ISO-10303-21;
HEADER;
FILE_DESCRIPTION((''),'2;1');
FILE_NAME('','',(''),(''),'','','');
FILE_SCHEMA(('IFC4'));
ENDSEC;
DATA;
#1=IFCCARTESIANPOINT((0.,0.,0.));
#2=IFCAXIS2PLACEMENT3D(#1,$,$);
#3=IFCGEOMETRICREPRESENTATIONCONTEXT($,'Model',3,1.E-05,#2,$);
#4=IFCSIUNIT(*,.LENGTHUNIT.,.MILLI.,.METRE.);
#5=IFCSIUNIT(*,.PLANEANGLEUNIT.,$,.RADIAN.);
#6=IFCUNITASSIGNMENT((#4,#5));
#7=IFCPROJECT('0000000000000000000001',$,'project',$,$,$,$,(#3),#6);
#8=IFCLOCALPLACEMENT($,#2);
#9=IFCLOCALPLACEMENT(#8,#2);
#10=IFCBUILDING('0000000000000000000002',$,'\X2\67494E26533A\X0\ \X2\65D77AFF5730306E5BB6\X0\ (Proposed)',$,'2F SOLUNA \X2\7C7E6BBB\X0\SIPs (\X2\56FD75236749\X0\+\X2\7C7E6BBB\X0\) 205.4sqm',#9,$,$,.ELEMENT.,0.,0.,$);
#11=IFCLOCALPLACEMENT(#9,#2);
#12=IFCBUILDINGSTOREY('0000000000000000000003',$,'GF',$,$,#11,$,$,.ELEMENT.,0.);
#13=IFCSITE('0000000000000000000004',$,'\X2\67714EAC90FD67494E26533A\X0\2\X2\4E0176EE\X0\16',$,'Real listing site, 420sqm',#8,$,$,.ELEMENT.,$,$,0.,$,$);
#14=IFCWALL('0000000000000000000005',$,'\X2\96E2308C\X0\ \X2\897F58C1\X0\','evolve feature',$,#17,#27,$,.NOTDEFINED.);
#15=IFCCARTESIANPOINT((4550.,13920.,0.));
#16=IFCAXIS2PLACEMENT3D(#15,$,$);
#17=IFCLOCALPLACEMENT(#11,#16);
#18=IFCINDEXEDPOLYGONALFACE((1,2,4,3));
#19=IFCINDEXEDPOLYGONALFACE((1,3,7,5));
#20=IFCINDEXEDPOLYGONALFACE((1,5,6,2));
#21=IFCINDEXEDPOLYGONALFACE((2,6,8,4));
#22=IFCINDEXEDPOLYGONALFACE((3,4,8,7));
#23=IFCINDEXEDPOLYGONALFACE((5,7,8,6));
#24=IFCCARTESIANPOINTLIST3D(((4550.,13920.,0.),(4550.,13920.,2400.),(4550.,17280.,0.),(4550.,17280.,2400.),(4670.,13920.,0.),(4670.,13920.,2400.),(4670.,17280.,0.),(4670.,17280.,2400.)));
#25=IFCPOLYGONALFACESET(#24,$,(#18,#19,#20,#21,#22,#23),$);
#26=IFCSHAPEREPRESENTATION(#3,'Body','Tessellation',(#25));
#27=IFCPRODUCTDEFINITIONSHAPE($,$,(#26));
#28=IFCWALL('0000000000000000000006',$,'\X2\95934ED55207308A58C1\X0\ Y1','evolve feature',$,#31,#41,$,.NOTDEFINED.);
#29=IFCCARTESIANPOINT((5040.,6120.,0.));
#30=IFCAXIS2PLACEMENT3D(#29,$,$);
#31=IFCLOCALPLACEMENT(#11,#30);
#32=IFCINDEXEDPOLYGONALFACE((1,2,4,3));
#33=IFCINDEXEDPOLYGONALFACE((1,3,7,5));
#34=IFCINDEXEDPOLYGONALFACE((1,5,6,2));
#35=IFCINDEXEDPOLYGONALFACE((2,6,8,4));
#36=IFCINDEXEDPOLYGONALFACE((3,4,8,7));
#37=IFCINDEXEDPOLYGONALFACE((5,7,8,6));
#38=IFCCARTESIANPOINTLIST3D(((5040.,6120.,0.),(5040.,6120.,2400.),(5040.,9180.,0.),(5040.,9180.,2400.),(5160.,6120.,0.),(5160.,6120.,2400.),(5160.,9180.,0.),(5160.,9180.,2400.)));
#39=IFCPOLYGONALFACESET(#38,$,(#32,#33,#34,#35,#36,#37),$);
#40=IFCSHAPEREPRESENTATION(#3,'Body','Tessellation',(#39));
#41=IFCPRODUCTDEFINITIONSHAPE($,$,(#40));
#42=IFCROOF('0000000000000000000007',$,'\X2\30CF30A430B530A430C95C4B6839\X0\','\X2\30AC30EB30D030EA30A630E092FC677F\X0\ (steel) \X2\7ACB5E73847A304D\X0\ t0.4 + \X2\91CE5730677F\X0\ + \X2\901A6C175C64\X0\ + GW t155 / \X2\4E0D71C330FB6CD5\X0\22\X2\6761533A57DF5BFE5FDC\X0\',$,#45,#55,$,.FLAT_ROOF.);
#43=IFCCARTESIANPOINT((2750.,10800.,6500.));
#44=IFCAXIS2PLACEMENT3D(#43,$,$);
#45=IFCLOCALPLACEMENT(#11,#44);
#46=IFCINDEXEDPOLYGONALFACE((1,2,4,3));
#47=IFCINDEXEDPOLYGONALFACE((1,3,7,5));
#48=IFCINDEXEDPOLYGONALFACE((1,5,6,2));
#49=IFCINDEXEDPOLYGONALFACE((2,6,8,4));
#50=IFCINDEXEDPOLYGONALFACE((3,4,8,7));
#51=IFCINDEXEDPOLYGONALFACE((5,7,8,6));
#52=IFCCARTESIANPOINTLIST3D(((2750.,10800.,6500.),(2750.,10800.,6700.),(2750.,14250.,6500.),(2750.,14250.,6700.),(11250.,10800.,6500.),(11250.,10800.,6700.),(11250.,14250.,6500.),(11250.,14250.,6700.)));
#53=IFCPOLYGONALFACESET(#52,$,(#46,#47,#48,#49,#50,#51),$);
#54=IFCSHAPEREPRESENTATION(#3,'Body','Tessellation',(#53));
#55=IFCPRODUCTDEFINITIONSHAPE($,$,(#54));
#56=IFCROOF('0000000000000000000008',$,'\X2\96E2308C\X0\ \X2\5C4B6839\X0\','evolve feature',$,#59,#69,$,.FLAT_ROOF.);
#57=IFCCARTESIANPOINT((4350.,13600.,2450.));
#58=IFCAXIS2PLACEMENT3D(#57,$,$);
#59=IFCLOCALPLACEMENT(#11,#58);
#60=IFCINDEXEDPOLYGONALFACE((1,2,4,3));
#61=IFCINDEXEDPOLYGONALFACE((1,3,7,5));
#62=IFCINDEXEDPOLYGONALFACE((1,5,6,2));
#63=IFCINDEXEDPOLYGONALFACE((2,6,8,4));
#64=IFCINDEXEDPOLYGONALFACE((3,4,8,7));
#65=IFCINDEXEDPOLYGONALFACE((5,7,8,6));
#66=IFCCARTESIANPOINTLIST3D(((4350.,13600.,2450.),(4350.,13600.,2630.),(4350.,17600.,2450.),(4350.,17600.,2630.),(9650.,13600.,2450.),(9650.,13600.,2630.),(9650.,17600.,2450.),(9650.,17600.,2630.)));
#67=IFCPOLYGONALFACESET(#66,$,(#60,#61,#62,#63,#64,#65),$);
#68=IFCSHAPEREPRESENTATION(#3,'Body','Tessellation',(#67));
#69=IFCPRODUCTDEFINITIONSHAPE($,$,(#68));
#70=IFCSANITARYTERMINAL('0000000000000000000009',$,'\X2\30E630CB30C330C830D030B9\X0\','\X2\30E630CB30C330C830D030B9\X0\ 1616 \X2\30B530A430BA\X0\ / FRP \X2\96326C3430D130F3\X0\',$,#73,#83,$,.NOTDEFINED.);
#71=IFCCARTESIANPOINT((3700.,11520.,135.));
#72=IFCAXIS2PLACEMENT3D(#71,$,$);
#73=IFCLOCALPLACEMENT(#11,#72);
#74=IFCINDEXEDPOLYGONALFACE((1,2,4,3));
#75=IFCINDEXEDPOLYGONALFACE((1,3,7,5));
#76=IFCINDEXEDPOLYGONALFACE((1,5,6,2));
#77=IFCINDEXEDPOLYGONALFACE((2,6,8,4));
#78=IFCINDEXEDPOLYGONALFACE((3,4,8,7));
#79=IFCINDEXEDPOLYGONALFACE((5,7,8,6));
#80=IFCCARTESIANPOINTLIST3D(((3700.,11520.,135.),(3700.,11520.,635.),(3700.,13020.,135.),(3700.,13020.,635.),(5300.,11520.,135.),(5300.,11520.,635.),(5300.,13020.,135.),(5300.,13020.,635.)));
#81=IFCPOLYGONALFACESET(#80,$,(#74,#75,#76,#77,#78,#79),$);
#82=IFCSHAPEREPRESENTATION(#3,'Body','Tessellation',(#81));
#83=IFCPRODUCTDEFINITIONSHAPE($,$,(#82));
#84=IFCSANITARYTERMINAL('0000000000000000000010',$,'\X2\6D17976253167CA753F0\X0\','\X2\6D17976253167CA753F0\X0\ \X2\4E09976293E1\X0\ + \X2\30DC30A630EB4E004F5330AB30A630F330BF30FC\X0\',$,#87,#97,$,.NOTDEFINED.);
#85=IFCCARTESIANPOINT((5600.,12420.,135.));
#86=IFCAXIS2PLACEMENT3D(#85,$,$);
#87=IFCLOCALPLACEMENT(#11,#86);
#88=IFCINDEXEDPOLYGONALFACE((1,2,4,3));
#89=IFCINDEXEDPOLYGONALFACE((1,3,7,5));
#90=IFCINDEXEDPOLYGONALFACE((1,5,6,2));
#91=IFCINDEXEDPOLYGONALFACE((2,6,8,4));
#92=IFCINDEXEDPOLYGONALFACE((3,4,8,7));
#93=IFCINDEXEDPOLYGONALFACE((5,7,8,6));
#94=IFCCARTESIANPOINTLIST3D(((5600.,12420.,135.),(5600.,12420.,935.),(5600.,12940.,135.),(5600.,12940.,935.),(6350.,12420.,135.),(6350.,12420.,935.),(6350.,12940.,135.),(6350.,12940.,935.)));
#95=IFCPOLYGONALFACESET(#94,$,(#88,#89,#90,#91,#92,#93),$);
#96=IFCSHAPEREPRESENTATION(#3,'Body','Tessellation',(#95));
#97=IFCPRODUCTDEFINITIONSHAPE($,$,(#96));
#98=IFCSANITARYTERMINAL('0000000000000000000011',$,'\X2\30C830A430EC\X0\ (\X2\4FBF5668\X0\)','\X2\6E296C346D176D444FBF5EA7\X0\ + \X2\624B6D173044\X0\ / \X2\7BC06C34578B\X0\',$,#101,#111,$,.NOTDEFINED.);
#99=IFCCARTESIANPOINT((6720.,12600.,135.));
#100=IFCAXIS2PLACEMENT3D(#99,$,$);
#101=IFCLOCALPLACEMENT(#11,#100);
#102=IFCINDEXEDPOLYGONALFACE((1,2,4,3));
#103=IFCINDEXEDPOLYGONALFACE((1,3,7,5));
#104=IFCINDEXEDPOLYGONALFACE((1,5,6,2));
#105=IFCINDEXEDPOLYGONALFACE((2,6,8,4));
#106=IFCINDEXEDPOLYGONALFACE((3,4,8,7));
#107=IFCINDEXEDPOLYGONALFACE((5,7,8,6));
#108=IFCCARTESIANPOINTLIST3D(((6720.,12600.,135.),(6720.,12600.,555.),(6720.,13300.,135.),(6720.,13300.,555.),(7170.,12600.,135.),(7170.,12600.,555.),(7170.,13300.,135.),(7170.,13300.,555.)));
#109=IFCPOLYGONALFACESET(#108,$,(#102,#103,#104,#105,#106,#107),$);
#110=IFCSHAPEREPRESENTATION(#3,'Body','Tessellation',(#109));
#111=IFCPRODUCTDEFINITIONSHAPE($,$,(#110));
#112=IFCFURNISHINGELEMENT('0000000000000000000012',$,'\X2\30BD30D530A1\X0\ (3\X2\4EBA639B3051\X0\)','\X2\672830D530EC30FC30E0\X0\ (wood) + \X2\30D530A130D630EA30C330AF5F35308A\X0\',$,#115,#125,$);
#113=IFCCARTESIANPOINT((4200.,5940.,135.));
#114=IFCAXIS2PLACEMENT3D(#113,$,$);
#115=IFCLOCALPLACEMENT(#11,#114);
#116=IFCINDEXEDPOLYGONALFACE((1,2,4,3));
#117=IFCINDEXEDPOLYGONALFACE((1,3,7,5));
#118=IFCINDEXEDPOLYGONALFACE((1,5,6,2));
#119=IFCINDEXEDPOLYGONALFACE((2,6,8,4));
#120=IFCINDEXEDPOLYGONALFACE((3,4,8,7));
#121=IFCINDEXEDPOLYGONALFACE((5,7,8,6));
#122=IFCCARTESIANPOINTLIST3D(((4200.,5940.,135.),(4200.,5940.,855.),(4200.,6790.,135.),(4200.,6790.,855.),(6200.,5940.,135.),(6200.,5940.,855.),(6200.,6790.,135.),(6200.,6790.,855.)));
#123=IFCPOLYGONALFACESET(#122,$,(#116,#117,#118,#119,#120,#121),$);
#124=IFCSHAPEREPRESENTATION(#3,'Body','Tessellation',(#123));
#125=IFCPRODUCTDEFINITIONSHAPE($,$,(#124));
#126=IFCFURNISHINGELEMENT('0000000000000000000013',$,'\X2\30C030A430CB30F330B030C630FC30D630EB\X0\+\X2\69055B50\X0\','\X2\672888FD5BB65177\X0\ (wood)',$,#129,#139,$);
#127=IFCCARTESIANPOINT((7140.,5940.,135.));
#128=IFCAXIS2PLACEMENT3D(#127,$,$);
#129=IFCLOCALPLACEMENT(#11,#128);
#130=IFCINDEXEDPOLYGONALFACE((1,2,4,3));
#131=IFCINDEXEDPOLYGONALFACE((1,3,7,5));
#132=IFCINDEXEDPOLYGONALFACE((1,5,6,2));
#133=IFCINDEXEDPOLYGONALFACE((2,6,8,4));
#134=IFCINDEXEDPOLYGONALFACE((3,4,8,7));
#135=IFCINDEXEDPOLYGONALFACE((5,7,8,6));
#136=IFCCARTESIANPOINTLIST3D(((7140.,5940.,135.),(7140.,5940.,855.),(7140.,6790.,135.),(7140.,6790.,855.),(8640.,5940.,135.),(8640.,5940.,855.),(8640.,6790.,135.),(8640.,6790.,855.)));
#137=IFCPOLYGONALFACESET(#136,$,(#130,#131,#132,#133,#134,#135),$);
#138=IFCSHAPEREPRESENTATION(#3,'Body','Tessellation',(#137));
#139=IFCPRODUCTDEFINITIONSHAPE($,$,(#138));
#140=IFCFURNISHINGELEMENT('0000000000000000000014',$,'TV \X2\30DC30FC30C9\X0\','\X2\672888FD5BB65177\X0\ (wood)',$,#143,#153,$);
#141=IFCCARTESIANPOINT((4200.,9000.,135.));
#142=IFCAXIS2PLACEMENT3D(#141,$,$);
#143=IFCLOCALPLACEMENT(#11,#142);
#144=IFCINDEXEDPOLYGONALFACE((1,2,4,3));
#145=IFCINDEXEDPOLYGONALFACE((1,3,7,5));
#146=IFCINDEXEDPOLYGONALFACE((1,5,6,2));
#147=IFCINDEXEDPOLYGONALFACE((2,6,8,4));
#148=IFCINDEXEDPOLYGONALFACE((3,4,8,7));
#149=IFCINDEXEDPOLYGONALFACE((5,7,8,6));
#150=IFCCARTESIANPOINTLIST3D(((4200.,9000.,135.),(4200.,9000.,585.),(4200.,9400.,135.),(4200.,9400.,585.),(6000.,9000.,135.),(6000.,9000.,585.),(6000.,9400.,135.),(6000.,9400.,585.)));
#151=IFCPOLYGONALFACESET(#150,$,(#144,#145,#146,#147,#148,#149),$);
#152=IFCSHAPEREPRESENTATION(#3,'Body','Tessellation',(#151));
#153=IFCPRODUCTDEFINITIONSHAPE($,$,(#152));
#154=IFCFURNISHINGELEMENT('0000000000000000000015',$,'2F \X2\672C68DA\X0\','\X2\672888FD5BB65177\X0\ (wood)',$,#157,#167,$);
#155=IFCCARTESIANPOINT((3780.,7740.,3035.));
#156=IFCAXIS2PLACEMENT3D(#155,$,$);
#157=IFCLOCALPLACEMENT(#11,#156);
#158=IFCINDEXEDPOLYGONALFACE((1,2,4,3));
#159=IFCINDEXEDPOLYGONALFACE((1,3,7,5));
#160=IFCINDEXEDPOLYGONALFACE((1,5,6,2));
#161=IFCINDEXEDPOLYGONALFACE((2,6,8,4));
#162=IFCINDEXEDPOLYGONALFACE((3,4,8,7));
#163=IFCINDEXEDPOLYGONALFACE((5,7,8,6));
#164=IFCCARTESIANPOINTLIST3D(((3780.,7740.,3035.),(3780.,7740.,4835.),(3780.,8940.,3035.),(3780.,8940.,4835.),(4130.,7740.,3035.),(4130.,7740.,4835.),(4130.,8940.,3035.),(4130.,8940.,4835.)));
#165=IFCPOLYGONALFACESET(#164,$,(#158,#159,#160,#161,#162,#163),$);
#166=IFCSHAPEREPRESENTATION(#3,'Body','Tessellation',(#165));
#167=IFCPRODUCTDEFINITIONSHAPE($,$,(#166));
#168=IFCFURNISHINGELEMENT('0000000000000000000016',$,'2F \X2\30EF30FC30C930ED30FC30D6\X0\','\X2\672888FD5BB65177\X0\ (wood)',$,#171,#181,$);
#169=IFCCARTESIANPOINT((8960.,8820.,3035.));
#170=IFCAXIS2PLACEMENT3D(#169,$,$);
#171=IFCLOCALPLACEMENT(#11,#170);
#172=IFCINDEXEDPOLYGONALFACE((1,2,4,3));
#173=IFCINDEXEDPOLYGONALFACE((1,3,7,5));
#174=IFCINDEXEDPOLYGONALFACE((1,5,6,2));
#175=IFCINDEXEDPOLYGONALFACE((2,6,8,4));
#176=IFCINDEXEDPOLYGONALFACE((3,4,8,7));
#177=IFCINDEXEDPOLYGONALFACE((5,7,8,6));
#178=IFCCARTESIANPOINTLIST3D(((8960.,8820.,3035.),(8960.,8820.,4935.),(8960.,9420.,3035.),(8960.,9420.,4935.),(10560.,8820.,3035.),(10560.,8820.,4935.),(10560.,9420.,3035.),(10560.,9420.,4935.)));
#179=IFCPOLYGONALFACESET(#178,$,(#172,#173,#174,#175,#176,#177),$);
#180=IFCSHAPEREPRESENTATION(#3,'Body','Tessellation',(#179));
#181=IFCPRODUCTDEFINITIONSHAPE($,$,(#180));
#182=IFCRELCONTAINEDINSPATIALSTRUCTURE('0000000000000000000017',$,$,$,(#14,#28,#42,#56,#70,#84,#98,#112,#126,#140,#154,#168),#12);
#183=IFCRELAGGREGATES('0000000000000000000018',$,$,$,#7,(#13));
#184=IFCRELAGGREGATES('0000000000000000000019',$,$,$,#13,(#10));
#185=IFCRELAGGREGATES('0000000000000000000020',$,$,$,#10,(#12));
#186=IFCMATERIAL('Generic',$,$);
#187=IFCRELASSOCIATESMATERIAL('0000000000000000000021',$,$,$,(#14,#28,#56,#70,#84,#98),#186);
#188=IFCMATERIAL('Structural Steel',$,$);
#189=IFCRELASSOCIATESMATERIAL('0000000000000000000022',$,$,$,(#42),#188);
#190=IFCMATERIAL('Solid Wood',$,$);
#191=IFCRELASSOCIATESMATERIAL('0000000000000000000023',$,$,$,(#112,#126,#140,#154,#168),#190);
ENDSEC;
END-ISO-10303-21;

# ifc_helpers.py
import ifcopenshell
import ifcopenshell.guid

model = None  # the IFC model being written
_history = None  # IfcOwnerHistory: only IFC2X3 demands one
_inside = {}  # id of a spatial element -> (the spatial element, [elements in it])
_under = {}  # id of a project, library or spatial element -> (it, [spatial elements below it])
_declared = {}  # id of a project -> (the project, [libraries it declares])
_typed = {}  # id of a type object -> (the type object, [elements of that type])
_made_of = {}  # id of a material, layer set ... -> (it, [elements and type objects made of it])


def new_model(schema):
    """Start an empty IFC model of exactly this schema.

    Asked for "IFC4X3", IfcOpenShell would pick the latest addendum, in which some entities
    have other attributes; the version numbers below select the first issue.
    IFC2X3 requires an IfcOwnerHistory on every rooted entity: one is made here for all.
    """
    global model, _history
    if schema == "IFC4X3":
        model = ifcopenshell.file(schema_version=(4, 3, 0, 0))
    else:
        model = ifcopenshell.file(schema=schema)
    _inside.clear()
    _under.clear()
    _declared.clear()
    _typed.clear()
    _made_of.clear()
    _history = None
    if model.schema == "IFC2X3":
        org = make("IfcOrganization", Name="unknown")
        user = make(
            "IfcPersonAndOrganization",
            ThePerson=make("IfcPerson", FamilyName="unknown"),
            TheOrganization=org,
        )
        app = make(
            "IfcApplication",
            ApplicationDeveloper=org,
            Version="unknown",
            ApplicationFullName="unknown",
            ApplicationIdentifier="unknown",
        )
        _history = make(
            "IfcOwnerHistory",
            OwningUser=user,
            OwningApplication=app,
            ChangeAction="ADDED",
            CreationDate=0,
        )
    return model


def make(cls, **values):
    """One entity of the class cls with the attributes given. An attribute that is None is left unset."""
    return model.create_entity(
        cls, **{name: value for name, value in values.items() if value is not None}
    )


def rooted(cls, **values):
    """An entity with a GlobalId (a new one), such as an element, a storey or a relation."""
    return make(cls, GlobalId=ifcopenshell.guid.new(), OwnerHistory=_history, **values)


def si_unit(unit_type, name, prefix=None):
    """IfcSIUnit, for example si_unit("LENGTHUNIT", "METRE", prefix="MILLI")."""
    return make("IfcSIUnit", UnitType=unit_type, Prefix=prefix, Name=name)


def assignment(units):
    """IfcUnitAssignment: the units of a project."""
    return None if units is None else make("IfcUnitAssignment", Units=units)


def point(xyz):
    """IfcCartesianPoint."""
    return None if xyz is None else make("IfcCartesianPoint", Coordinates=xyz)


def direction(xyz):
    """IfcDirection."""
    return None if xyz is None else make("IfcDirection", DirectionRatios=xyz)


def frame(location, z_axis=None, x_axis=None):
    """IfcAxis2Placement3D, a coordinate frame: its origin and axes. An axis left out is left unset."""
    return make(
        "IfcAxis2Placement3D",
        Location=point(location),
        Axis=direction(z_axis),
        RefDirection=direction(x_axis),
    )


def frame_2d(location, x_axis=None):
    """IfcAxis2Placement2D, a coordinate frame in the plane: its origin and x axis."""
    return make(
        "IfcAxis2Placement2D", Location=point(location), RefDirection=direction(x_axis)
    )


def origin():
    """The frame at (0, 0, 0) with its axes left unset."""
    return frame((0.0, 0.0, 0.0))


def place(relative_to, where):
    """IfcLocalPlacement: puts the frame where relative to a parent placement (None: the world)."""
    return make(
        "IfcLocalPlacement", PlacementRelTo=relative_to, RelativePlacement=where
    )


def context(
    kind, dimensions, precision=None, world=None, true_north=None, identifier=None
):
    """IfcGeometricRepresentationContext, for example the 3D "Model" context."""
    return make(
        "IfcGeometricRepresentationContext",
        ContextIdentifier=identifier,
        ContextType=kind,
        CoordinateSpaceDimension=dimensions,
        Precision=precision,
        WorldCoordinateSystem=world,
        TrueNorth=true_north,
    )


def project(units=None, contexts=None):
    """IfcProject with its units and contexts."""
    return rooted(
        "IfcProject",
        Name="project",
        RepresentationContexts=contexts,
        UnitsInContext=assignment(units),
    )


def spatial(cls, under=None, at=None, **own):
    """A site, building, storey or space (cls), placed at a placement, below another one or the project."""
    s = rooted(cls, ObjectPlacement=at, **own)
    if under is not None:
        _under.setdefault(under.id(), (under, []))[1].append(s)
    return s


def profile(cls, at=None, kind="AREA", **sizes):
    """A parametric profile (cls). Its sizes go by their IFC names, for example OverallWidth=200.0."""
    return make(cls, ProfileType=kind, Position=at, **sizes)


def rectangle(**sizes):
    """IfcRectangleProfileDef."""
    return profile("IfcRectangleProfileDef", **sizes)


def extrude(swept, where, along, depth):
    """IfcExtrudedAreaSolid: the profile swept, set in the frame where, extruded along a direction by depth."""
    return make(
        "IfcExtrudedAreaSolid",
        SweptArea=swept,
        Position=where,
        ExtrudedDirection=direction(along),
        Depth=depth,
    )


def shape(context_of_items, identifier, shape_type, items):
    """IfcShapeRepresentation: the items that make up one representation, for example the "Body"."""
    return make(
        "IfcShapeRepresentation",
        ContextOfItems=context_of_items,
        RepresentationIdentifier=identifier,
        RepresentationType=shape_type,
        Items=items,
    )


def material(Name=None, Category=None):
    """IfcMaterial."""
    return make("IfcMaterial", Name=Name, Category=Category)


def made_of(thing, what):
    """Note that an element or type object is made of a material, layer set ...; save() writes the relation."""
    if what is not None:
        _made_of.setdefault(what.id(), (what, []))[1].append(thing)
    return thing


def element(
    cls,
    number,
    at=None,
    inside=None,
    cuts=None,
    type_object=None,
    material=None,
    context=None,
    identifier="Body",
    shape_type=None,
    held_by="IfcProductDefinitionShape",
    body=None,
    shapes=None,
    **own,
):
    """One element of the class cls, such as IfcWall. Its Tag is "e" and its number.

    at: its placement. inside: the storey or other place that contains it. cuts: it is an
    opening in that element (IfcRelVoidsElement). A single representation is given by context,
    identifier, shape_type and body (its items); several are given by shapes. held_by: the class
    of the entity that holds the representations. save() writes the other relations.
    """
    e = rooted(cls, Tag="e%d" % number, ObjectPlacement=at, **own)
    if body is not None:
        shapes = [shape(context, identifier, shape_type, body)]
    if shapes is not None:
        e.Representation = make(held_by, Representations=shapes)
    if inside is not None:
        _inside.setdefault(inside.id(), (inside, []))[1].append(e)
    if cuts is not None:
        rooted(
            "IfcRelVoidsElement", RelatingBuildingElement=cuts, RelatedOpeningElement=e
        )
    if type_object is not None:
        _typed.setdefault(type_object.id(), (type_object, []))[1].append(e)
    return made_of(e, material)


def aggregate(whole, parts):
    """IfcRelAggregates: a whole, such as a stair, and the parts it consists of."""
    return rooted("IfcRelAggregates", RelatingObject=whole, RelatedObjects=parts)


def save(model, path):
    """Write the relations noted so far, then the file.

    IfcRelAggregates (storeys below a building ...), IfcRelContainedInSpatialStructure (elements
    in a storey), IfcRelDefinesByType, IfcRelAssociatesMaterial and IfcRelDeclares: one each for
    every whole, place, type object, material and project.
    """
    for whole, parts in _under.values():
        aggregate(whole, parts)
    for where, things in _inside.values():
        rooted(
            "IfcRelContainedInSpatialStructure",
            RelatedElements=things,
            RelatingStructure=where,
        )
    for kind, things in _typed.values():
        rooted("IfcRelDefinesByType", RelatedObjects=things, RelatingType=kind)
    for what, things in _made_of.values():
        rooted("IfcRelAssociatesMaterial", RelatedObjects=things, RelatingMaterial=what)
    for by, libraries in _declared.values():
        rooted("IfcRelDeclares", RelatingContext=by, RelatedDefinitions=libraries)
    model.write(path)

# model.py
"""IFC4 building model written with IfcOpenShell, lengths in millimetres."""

from ifc_helpers import new_model, si_unit, frame, frame_2d, origin, place, context, project, spatial, rectangle, extrude, material, element, save


model = new_model("IFC4")

# Units and contexts
model_context = context("Model", 3, precision=1e-05, world=origin())
ifc_project = project(units=[si_unit("LENGTHUNIT", "METRE", prefix="MILLI"), si_unit("PLANEANGLEUNIT", "RADIAN")], contexts=[model_context])

# Site, building, storey
site_placement = place(None, origin())
site = spatial("IfcSite", under=ifc_project, at=site_placement, Name="東京都杉並区2丁目16", ObjectType="Real listing site, 420sqm", CompositionType="ELEMENT", RefElevation=0.0)
building_placement = place(site_placement, origin())
building = spatial("IfcBuilding", under=site, at=building_placement, Name="杉並区 旗竿地の家 (Proposed)", ObjectType="2F SOLUNA 籾殻SIPs (国産杉+籾殻) 205.4sqm", CompositionType="ELEMENT", ElevationOfRefHeight=0.0, ElevationOfTerrain=0.0)
storey_placement = place(building_placement, origin())
storey = spatial("IfcBuildingStorey", under=building, at=storey_placement, Name="GF", CompositionType="ELEMENT", Elevation=0.0)

# Shared definitions
ifc_material_1 = material(Name="Generic")

# Shared definitions
ifc_material_2 = material(Name="Solid Wood")

# Walls
wall_1_placement = place(storey_placement, frame((4550.0, 13920.0, 0.0)))
element("IfcWall", 1, at=wall_1_placement, inside=storey, material=ifc_material_1, Name="離れ 西壁", Description="evolve feature", PredefinedType="NOTDEFINED", context=model_context, shape_type="SweptSolid", body=[
    extrude(rectangle(XDim=120.0, YDim=3360.0, at=frame_2d((60.0, 1680.0))), frame((4550.0, 13920.0, 0.0)), (0.0, 0.0, 1.0), 2400.0),
])
wall_2_placement = place(storey_placement, frame((5040.0, 6120.0, 0.0)))
element("IfcWall", 2, at=wall_2_placement, inside=storey, material=ifc_material_1, Name="間仕切り壁 Y1", Description="evolve feature", PredefinedType="NOTDEFINED", context=model_context, shape_type="SweptSolid", body=[
    extrude(rectangle(XDim=120.0, YDim=3060.0, at=frame_2d((60.0, 1530.0))), frame((5040.0, 6120.0, 0.0)), (0.0, 0.0, 1.0), 2400.0),
])

# Roofs
ifc_material_3 = material(Name="Structural Steel")
roof_1_placement = place(storey_placement, frame((2750.0, 10800.0, 6500.0)))
element("IfcRoof", 3, at=roof_1_placement, inside=storey, material=ifc_material_3, Name="ハイサイド屋根", Description="ガルバリウム鋼板 (steel) 立平葺き t0.4 + 野地板 + 通気層 + GW t155 / 不燃・法22条区域対応", PredefinedType="FLAT_ROOF", context=model_context, shape_type="SweptSolid", body=[
    extrude(rectangle(XDim=8500.0, YDim=3450.0, at=frame_2d((4250.0, 1725.0))), frame((2750.0, 10800.0, 6500.0)), (0.0, 0.0, 1.0), 200.0),
])
roof_2_placement = place(storey_placement, frame((4350.0, 13600.0, 2450.0)))
element("IfcRoof", 4, at=roof_2_placement, inside=storey, material=ifc_material_1, Name="離れ 屋根", Description="evolve feature", PredefinedType="FLAT_ROOF", context=model_context, shape_type="SweptSolid", body=[
    extrude(rectangle(XDim=5300.0, YDim=4000.0, at=frame_2d((2650.0, 2000.0))), frame((4350.0, 13600.0, 2450.0)), (0.0, 0.0, 1.0), 180.0),
])

# Sanitary terminals
sanitary_terminal_1_placement = place(storey_placement, frame((3700.0, 11520.0, 135.0)))
element("IfcSanitaryTerminal", 5, at=sanitary_terminal_1_placement, inside=storey, material=ifc_material_1, Name="ユニットバス", Description="ユニットバス 1616 サイズ / FRP 防水パン", PredefinedType="NOTDEFINED", context=model_context, shape_type="SweptSolid", body=[
    extrude(rectangle(XDim=1600.0, YDim=1500.0, at=frame_2d((800.0, 750.0))), frame((3700.0, 11520.0, 135.0)), (0.0, 0.0, 1.0), 500.0),
])
sanitary_terminal_2_placement = place(storey_placement, frame((5600.0, 12420.0, 135.0)))
element("IfcSanitaryTerminal", 6, at=sanitary_terminal_2_placement, inside=storey, material=ifc_material_1, Name="洗面化粧台", Description="洗面化粧台 三面鏡 + ボウル一体カウンター", PredefinedType="NOTDEFINED", context=model_context, shape_type="SweptSolid", body=[
    extrude(rectangle(XDim=750.0, YDim=520.0, at=frame_2d((375.0, 260.0))), frame((5600.0, 12420.0, 135.0)), (0.0, 0.0, 1.0), 800.0),
])
sanitary_terminal_3_placement = place(storey_placement, frame((6720.0, 12600.0, 135.0)))
element("IfcSanitaryTerminal", 7, at=sanitary_terminal_3_placement, inside=storey, material=ifc_material_1, Name="トイレ (便器)", Description="温水洗浄便座 + 手洗い / 節水型", PredefinedType="NOTDEFINED", context=model_context, shape_type="SweptSolid", body=[
    extrude(rectangle(XDim=450.0, YDim=700.0, at=frame_2d((225.0, 350.0))), frame((6720.0, 12600.0, 135.0)), (0.0, 0.0, 1.0), 420.0),
])

# Furnishing elements
furnishing_1_placement = place(storey_placement, frame((4200.0, 5940.0, 135.0)))
element("IfcFurnishingElement", 8, at=furnishing_1_placement, inside=storey, material=ifc_material_2, Name="ソファ (3人掛け)", Description="木フレーム (wood) + ファブリック張り", context=model_context, shape_type="SweptSolid", body=[
    extrude(rectangle(XDim=2000.0, YDim=850.0, at=frame_2d((1000.0, 425.0))), frame((4200.0, 5940.0, 135.0)), (0.0, 0.0, 1.0), 720.0),
])
furnishing_2_placement = place(storey_placement, frame((7140.0, 5940.0, 135.0)))
element("IfcFurnishingElement", 9, at=furnishing_2_placement, inside=storey, material=ifc_material_2, Name="ダイニングテーブル+椅子", Description="木製家具 (wood)", context=model_context, shape_type="SweptSolid", body=[
    extrude(rectangle(XDim=1500.0, YDim=850.0, at=frame_2d((750.0, 425.0))), frame((7140.0, 5940.0, 135.0)), (0.0, 0.0, 1.0), 720.0),
])
furnishing_3_placement = place(storey_placement, frame((4200.0, 9000.0, 135.0)))
element("IfcFurnishingElement", 10, at=furnishing_3_placement, inside=storey, material=ifc_material_2, Name="TV ボード", Description="木製家具 (wood)", context=model_context, shape_type="SweptSolid", body=[
    extrude(rectangle(XDim=1800.0, YDim=400.0, at=frame_2d((900.0, 200.0))), frame((4200.0, 9000.0, 135.0)), (0.0, 0.0, 1.0), 450.0),
])
furnishing_4_placement = place(storey_placement, frame((3780.0, 7740.0, 3035.0)))
element("IfcFurnishingElement", 11, at=furnishing_4_placement, inside=storey, material=ifc_material_2, Name="2F 本棚", Description="木製家具 (wood)", context=model_context, shape_type="SweptSolid", body=[
    extrude(rectangle(XDim=350.0, YDim=1200.0, at=frame_2d((175.0, 600.0))), frame((3780.0, 7740.0, 3035.0)), (0.0, 0.0, 1.0), 1800.0),
])
furnishing_5_placement = place(storey_placement, frame((8960.0, 8820.0, 3035.0)))
element("IfcFurnishingElement", 12, at=furnishing_5_placement, inside=storey, material=ifc_material_2, Name="2F ワードローブ", Description="木製家具 (wood)", context=model_context, shape_type="SweptSolid", body=[
    extrude(rectangle(XDim=1600.0, YDim=600.0, at=frame_2d((800.0, 300.0))), frame((8960.0, 8820.0, 3035.0)), (0.0, 0.0, 1.0), 1900.0),
])

save(model, "model.ifc")
